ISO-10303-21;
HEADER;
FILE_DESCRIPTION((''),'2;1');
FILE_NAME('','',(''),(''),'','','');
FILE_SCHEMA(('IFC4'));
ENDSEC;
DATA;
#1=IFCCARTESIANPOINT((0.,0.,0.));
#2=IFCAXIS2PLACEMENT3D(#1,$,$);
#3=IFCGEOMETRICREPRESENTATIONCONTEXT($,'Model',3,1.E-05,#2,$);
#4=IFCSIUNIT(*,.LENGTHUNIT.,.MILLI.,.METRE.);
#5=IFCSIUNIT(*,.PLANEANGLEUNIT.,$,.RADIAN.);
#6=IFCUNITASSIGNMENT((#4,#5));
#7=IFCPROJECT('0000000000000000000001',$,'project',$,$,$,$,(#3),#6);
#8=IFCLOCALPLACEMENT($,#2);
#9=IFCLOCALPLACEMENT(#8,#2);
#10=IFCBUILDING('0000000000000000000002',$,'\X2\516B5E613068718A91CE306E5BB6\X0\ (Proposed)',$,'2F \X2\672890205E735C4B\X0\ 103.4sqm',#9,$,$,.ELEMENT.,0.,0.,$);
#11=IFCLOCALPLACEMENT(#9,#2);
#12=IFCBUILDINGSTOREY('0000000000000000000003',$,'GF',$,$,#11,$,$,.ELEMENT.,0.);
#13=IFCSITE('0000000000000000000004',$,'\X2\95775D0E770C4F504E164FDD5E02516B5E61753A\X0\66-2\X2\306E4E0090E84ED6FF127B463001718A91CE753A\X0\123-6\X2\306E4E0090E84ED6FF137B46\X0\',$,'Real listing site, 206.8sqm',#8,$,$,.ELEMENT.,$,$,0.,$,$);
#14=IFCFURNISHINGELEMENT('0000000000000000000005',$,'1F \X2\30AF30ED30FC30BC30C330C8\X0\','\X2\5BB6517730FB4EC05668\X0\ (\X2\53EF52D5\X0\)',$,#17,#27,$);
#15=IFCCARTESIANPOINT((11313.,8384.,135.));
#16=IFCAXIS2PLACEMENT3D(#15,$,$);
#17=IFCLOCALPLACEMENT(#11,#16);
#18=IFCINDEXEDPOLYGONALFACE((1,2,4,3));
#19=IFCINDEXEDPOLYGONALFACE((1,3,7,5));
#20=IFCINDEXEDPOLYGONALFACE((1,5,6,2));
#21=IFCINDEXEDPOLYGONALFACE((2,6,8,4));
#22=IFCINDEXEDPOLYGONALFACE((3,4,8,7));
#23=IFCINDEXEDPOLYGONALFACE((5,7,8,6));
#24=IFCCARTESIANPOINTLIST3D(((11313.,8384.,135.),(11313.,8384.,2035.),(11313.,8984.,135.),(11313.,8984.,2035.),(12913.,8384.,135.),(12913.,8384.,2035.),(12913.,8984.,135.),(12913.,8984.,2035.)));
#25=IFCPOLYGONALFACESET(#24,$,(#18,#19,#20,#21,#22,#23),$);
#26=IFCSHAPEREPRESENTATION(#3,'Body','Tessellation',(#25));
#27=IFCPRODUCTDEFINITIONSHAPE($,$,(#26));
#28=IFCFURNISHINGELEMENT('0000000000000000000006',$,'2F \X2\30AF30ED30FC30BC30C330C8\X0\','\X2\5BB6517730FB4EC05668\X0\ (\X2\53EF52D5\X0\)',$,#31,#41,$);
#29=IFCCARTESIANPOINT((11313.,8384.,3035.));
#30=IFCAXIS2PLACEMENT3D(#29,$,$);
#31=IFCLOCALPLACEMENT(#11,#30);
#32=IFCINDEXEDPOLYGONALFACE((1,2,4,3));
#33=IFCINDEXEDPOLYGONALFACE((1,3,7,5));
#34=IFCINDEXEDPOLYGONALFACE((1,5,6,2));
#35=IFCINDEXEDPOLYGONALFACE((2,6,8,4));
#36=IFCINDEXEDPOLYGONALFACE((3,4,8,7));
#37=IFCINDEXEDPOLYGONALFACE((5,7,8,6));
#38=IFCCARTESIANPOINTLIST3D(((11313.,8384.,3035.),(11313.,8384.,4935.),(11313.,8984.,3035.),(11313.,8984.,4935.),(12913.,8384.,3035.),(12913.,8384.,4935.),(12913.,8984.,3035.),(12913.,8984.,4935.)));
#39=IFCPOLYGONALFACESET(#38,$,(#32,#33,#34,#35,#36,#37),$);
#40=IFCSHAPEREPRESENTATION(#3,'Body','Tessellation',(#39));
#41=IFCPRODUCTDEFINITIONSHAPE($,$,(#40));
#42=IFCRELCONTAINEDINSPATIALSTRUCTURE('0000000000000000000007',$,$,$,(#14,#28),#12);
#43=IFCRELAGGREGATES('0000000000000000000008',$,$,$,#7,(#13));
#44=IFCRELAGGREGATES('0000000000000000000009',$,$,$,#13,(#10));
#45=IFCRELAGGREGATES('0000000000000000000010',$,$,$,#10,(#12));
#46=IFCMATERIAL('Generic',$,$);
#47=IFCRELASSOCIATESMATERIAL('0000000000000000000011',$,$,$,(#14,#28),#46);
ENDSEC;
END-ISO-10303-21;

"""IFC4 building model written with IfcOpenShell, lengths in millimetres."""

from ifc_helpers import new_model, si_unit, frame, frame_2d, origin, place, context, project, spatial, rectangle, extrude, material, element, save


model = new_model("IFC4")

# Units and contexts
model_context = context("Model", 3, precision=1e-05, world=origin())
ifc_project = project(units=[si_unit("LENGTHUNIT", "METRE", prefix="MILLI"), si_unit("PLANEANGLEUNIT", "RADIAN")], contexts=[model_context])

# Site, building, storey
site_placement = place(None, origin())
site = spatial("IfcSite", under=ifc_project, at=site_placement, Name="長崎県佐世保市八幡町66-2の一部他２筆、熊野町123-6の一部他３筆", ObjectType="Real listing site, 206.8sqm", CompositionType="ELEMENT", RefElevation=0.0)
building_placement = place(site_placement, origin())
building = spatial("IfcBuilding", under=site, at=building_placement, Name="八幡と熊野の家 (Proposed)", ObjectType="2F 木造平屋 103.4sqm", CompositionType="ELEMENT", ElevationOfRefHeight=0.0, ElevationOfTerrain=0.0)
storey_placement = place(building_placement, origin())
storey = spatial("IfcBuildingStorey", under=building, at=storey_placement, Name="GF", CompositionType="ELEMENT", Elevation=0.0)

# Shared definitions
ifc_material_1 = material(Name="Generic")

# Furnishing elements
furnishing_1_placement = place(storey_placement, frame((11313.0, 8384.0, 135.0)))
element("IfcFurnishingElement", 1, at=furnishing_1_placement, inside=storey, material=ifc_material_1, Name="1F クローゼット", Description="家具・什器 (可動)", context=model_context, shape_type="SweptSolid", body=[
    extrude(rectangle(XDim=1600.0, YDim=600.0, at=frame_2d((800.0, 300.0))), frame((11313.0, 8384.0, 135.0)), (0.0, 0.0, 1.0), 1900.0),
])
furnishing_2_placement = place(storey_placement, frame((11313.0, 8384.0, 3035.0)))
element("IfcFurnishingElement", 2, at=furnishing_2_placement, inside=storey, material=ifc_material_1, Name="2F クローゼット", Description="家具・什器 (可動)", context=model_context, shape_type="SweptSolid", body=[
    extrude(rectangle(XDim=1600.0, YDim=600.0, at=frame_2d((800.0, 300.0))), frame((11313.0, 8384.0, 3035.0)), (0.0, 0.0, 1.0), 1900.0),
])

save(model, "model.ifc")
